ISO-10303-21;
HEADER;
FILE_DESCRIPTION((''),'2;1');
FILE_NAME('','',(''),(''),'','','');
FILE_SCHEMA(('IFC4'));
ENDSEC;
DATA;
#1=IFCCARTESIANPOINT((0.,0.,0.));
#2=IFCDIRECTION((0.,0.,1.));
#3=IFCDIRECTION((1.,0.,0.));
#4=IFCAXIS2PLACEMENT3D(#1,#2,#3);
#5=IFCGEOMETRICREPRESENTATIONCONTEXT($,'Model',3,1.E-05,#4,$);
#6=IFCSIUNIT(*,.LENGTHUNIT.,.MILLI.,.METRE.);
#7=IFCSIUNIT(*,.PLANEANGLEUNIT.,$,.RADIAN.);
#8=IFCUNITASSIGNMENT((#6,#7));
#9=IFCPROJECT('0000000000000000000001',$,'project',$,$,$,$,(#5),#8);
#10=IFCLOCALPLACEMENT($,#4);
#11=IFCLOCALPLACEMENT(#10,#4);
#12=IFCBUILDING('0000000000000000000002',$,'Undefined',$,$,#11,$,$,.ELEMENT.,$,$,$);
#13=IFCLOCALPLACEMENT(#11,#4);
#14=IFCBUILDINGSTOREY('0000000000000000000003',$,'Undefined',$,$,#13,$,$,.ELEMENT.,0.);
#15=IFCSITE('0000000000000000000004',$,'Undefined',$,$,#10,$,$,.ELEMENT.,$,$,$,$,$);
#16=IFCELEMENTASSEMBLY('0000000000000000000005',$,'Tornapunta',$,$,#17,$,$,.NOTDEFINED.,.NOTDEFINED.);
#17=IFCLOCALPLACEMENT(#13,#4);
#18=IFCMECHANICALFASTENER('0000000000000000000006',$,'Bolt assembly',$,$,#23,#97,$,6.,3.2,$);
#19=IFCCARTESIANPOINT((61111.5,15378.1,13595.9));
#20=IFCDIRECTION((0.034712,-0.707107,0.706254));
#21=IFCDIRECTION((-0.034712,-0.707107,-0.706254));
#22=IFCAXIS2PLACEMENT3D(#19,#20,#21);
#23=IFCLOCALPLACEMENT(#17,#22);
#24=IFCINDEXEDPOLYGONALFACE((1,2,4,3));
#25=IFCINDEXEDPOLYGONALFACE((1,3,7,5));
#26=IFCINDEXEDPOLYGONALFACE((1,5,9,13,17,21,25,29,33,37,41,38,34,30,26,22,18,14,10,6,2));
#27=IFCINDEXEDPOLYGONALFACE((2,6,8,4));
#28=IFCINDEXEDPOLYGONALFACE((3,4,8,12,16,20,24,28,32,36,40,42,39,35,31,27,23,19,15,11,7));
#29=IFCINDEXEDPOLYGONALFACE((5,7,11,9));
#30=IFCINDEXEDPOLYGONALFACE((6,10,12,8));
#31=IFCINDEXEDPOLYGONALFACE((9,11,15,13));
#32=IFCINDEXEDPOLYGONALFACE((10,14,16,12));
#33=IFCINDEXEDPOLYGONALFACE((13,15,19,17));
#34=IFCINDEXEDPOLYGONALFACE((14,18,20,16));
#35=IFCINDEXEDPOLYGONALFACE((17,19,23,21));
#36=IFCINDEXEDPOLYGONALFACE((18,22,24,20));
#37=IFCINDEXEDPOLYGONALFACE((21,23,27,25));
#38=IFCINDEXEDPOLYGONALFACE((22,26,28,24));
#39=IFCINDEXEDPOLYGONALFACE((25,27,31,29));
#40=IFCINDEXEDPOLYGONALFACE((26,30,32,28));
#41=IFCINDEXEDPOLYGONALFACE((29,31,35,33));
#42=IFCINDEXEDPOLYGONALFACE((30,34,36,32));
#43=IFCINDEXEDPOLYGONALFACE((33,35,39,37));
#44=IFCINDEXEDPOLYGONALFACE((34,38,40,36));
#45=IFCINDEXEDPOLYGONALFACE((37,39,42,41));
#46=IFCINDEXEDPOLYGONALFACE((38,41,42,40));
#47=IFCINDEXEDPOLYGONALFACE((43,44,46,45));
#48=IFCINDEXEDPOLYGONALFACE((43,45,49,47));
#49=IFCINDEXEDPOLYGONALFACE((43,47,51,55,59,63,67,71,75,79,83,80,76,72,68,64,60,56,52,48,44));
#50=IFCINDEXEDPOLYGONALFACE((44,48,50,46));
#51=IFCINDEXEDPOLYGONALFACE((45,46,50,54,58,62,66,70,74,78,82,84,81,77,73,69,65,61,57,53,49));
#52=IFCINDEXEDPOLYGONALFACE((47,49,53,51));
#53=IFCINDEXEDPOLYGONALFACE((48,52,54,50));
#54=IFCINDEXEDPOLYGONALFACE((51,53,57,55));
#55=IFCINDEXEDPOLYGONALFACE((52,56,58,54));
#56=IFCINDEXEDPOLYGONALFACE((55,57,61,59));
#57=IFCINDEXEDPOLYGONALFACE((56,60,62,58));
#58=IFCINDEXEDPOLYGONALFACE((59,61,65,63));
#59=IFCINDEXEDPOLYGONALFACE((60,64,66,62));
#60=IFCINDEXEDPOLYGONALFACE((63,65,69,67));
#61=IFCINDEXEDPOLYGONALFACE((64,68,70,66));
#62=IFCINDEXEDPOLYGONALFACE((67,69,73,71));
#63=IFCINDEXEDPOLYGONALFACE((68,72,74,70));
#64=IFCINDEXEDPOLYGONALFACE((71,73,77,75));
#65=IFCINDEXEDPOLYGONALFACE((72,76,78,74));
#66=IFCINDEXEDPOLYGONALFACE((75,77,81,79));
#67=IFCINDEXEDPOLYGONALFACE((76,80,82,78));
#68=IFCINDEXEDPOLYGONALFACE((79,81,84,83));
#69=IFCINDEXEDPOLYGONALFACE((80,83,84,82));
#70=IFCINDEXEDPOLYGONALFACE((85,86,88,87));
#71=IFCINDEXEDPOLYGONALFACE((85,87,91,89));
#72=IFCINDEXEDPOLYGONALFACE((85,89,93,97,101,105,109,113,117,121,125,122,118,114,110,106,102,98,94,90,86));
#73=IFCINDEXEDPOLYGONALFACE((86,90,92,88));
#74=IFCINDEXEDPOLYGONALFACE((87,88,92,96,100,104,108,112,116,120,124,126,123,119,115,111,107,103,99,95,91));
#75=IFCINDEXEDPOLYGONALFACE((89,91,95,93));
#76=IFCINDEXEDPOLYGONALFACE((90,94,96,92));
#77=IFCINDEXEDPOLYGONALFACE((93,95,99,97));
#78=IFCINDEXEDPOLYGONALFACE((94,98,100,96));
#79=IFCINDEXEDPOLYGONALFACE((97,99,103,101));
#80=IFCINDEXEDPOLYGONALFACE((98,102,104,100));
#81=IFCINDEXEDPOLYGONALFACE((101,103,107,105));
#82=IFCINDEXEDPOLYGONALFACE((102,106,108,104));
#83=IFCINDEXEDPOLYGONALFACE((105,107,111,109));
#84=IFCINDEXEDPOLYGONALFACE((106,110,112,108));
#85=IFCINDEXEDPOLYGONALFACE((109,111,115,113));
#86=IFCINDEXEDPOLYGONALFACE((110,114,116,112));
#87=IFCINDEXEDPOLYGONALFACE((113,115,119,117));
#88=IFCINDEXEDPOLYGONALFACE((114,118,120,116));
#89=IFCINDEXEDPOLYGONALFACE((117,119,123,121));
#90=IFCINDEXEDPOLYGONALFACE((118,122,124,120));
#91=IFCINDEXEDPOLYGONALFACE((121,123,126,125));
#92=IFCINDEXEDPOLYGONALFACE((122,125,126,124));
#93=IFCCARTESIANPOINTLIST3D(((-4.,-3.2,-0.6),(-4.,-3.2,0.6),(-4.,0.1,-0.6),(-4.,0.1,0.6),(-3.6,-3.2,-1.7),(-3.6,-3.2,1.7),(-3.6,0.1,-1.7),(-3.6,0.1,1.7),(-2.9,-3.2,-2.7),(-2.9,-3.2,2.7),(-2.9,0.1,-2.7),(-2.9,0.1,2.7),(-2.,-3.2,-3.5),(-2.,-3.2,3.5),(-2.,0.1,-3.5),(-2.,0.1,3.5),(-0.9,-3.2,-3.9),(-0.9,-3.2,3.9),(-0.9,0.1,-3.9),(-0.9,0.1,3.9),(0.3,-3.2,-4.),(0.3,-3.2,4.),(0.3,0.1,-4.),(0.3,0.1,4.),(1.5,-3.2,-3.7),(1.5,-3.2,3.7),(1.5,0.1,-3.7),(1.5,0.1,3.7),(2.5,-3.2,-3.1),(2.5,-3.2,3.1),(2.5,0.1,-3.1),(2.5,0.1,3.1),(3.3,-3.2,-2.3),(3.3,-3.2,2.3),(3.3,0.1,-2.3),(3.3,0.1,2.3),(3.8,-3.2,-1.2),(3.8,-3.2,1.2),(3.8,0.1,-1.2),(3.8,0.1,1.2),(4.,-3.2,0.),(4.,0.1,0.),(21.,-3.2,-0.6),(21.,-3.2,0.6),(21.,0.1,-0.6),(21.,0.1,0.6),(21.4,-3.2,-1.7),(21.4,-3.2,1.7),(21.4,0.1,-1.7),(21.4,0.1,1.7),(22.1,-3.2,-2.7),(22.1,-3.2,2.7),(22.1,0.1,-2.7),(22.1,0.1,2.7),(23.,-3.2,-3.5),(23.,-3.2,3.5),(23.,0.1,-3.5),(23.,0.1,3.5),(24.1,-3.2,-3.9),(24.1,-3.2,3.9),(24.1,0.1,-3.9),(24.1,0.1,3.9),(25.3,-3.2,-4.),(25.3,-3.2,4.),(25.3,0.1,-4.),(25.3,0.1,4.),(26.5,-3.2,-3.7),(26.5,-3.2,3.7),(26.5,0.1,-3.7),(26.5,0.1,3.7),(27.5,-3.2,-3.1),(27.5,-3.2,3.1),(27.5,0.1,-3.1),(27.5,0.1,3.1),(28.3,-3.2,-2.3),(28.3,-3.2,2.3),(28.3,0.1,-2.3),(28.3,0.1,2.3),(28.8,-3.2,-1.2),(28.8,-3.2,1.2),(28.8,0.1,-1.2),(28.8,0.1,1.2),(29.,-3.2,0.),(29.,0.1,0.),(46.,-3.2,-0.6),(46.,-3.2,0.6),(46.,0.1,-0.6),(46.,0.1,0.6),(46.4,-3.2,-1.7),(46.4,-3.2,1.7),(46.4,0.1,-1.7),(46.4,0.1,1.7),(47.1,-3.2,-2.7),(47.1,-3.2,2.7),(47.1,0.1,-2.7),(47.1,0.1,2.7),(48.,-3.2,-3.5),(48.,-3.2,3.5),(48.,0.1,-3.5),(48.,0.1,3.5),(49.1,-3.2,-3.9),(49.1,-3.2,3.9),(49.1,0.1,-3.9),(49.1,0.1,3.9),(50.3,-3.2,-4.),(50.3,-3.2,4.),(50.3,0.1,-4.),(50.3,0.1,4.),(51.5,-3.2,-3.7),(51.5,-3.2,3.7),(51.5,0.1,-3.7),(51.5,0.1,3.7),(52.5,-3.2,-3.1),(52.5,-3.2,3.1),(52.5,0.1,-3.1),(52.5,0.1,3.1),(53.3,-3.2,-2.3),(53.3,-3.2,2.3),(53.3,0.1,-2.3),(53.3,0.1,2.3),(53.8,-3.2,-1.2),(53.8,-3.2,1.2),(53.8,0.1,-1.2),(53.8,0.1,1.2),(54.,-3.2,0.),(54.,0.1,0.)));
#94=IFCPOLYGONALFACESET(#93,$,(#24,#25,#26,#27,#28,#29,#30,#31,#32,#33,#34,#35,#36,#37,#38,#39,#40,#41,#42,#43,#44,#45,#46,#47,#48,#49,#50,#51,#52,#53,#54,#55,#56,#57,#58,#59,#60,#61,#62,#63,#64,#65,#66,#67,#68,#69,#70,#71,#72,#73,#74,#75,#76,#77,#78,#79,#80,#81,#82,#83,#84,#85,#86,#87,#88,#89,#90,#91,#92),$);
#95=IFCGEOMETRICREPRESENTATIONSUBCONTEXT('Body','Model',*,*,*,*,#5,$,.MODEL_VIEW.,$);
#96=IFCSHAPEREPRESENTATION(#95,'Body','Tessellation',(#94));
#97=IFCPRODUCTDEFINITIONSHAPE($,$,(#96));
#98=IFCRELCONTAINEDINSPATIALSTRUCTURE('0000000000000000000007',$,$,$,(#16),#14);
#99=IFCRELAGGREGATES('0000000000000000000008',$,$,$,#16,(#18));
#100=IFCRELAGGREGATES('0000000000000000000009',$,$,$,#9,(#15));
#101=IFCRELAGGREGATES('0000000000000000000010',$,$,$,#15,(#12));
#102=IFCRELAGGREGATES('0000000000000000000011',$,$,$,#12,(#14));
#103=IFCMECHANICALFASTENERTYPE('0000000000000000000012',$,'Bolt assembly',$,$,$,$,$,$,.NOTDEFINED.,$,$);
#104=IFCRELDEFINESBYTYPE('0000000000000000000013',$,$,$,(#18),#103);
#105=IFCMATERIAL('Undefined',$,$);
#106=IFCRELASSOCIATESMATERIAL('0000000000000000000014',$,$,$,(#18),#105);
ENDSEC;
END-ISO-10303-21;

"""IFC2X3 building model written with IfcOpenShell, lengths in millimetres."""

from ifc_helpers import new_model, si_unit, frame, origin_with_axes, origin_2d_with_axis, place, context, subcontext, project, spatial, circle, extrude, source, transform, mapped, material, type_object, element, aggregate, save


model = new_model("IFC2X3")

# Units and contexts
model_context = context("Model", 3, precision=1e-05, world=origin_with_axes())
body_context = subcontext(model_context, "Body", "Model", "MODEL_VIEW")
ifc_project = project(units=[si_unit("LENGTHUNIT", "METRE", prefix="MILLI"), si_unit("PLANEANGLEUNIT", "RADIAN")], contexts=[model_context])

# Site, building, storey
site_placement = place(None, origin_with_axes())
site = spatial("IfcSite", under=ifc_project, at=site_placement, Name="Undefined", CompositionType="ELEMENT")
building_placement = place(site_placement, origin_with_axes())
building = spatial("IfcBuilding", under=site, at=building_placement, Name="Undefined", CompositionType="ELEMENT")
storey_placement = place(building_placement, origin_with_axes())
storey = spatial("IfcBuildingStorey", under=building, at=storey_placement, Name="Undefined", CompositionType="ELEMENT", Elevation=0.0)

# Shared definitions
mechanical_fastener_type = type_object("IfcMechanicalFastenerType", Name="Bolt assembly")

# Element assembly, mechanical fastener
ifc_material_1 = material(Name="Undefined")
shared_shape_1 = source(origin_with_axes(), body_context, "Body", "SweptSolid", [
    extrude(circle(Radius=4.0, at=origin_2d_with_axis()), frame((0.0, -3.2, 0.0), z_axis=(0.0, 1.0, 0.0), x_axis=(1.0, 0.0, 0.0)), (0.0, 0.0, 1.0), 3.3),
])
assembly_1_placement = place(storey_placement, origin_with_axes())
assembly_1 = element("IfcElementAssembly", 1, at=assembly_1_placement, inside=storey, Name="Tornapunta", AssemblyPlace="NOTDEFINED", PredefinedType="NOTDEFINED")
mechanical_fastener_1_placement = place(assembly_1_placement, frame((61111.5, 15378.1, 13595.9), z_axis=(0.034712, -0.707107, 0.706254), x_axis=(-0.034712, -0.707107, -0.706254)))
mechanical_fastener_1 = element("IfcMechanicalFastener", 2, at=mechanical_fastener_1_placement, type_object=mechanical_fastener_type, material=ifc_material_1, Name="Bolt assembly", NominalDiameter=6.0, NominalLength=3.2, context=body_context, shape_type="MappedRepresentation", body=[
    mapped(shared_shape_1, transform((0.0, 0.0, 0.0))),
    mapped(shared_shape_1, transform((25.0, 0.0, 0.0))),
    mapped(shared_shape_1, transform((50.0, 0.0, 0.0))),
])
aggregate(assembly_1, [mechanical_fastener_1])

save(model, "model.ifc")
